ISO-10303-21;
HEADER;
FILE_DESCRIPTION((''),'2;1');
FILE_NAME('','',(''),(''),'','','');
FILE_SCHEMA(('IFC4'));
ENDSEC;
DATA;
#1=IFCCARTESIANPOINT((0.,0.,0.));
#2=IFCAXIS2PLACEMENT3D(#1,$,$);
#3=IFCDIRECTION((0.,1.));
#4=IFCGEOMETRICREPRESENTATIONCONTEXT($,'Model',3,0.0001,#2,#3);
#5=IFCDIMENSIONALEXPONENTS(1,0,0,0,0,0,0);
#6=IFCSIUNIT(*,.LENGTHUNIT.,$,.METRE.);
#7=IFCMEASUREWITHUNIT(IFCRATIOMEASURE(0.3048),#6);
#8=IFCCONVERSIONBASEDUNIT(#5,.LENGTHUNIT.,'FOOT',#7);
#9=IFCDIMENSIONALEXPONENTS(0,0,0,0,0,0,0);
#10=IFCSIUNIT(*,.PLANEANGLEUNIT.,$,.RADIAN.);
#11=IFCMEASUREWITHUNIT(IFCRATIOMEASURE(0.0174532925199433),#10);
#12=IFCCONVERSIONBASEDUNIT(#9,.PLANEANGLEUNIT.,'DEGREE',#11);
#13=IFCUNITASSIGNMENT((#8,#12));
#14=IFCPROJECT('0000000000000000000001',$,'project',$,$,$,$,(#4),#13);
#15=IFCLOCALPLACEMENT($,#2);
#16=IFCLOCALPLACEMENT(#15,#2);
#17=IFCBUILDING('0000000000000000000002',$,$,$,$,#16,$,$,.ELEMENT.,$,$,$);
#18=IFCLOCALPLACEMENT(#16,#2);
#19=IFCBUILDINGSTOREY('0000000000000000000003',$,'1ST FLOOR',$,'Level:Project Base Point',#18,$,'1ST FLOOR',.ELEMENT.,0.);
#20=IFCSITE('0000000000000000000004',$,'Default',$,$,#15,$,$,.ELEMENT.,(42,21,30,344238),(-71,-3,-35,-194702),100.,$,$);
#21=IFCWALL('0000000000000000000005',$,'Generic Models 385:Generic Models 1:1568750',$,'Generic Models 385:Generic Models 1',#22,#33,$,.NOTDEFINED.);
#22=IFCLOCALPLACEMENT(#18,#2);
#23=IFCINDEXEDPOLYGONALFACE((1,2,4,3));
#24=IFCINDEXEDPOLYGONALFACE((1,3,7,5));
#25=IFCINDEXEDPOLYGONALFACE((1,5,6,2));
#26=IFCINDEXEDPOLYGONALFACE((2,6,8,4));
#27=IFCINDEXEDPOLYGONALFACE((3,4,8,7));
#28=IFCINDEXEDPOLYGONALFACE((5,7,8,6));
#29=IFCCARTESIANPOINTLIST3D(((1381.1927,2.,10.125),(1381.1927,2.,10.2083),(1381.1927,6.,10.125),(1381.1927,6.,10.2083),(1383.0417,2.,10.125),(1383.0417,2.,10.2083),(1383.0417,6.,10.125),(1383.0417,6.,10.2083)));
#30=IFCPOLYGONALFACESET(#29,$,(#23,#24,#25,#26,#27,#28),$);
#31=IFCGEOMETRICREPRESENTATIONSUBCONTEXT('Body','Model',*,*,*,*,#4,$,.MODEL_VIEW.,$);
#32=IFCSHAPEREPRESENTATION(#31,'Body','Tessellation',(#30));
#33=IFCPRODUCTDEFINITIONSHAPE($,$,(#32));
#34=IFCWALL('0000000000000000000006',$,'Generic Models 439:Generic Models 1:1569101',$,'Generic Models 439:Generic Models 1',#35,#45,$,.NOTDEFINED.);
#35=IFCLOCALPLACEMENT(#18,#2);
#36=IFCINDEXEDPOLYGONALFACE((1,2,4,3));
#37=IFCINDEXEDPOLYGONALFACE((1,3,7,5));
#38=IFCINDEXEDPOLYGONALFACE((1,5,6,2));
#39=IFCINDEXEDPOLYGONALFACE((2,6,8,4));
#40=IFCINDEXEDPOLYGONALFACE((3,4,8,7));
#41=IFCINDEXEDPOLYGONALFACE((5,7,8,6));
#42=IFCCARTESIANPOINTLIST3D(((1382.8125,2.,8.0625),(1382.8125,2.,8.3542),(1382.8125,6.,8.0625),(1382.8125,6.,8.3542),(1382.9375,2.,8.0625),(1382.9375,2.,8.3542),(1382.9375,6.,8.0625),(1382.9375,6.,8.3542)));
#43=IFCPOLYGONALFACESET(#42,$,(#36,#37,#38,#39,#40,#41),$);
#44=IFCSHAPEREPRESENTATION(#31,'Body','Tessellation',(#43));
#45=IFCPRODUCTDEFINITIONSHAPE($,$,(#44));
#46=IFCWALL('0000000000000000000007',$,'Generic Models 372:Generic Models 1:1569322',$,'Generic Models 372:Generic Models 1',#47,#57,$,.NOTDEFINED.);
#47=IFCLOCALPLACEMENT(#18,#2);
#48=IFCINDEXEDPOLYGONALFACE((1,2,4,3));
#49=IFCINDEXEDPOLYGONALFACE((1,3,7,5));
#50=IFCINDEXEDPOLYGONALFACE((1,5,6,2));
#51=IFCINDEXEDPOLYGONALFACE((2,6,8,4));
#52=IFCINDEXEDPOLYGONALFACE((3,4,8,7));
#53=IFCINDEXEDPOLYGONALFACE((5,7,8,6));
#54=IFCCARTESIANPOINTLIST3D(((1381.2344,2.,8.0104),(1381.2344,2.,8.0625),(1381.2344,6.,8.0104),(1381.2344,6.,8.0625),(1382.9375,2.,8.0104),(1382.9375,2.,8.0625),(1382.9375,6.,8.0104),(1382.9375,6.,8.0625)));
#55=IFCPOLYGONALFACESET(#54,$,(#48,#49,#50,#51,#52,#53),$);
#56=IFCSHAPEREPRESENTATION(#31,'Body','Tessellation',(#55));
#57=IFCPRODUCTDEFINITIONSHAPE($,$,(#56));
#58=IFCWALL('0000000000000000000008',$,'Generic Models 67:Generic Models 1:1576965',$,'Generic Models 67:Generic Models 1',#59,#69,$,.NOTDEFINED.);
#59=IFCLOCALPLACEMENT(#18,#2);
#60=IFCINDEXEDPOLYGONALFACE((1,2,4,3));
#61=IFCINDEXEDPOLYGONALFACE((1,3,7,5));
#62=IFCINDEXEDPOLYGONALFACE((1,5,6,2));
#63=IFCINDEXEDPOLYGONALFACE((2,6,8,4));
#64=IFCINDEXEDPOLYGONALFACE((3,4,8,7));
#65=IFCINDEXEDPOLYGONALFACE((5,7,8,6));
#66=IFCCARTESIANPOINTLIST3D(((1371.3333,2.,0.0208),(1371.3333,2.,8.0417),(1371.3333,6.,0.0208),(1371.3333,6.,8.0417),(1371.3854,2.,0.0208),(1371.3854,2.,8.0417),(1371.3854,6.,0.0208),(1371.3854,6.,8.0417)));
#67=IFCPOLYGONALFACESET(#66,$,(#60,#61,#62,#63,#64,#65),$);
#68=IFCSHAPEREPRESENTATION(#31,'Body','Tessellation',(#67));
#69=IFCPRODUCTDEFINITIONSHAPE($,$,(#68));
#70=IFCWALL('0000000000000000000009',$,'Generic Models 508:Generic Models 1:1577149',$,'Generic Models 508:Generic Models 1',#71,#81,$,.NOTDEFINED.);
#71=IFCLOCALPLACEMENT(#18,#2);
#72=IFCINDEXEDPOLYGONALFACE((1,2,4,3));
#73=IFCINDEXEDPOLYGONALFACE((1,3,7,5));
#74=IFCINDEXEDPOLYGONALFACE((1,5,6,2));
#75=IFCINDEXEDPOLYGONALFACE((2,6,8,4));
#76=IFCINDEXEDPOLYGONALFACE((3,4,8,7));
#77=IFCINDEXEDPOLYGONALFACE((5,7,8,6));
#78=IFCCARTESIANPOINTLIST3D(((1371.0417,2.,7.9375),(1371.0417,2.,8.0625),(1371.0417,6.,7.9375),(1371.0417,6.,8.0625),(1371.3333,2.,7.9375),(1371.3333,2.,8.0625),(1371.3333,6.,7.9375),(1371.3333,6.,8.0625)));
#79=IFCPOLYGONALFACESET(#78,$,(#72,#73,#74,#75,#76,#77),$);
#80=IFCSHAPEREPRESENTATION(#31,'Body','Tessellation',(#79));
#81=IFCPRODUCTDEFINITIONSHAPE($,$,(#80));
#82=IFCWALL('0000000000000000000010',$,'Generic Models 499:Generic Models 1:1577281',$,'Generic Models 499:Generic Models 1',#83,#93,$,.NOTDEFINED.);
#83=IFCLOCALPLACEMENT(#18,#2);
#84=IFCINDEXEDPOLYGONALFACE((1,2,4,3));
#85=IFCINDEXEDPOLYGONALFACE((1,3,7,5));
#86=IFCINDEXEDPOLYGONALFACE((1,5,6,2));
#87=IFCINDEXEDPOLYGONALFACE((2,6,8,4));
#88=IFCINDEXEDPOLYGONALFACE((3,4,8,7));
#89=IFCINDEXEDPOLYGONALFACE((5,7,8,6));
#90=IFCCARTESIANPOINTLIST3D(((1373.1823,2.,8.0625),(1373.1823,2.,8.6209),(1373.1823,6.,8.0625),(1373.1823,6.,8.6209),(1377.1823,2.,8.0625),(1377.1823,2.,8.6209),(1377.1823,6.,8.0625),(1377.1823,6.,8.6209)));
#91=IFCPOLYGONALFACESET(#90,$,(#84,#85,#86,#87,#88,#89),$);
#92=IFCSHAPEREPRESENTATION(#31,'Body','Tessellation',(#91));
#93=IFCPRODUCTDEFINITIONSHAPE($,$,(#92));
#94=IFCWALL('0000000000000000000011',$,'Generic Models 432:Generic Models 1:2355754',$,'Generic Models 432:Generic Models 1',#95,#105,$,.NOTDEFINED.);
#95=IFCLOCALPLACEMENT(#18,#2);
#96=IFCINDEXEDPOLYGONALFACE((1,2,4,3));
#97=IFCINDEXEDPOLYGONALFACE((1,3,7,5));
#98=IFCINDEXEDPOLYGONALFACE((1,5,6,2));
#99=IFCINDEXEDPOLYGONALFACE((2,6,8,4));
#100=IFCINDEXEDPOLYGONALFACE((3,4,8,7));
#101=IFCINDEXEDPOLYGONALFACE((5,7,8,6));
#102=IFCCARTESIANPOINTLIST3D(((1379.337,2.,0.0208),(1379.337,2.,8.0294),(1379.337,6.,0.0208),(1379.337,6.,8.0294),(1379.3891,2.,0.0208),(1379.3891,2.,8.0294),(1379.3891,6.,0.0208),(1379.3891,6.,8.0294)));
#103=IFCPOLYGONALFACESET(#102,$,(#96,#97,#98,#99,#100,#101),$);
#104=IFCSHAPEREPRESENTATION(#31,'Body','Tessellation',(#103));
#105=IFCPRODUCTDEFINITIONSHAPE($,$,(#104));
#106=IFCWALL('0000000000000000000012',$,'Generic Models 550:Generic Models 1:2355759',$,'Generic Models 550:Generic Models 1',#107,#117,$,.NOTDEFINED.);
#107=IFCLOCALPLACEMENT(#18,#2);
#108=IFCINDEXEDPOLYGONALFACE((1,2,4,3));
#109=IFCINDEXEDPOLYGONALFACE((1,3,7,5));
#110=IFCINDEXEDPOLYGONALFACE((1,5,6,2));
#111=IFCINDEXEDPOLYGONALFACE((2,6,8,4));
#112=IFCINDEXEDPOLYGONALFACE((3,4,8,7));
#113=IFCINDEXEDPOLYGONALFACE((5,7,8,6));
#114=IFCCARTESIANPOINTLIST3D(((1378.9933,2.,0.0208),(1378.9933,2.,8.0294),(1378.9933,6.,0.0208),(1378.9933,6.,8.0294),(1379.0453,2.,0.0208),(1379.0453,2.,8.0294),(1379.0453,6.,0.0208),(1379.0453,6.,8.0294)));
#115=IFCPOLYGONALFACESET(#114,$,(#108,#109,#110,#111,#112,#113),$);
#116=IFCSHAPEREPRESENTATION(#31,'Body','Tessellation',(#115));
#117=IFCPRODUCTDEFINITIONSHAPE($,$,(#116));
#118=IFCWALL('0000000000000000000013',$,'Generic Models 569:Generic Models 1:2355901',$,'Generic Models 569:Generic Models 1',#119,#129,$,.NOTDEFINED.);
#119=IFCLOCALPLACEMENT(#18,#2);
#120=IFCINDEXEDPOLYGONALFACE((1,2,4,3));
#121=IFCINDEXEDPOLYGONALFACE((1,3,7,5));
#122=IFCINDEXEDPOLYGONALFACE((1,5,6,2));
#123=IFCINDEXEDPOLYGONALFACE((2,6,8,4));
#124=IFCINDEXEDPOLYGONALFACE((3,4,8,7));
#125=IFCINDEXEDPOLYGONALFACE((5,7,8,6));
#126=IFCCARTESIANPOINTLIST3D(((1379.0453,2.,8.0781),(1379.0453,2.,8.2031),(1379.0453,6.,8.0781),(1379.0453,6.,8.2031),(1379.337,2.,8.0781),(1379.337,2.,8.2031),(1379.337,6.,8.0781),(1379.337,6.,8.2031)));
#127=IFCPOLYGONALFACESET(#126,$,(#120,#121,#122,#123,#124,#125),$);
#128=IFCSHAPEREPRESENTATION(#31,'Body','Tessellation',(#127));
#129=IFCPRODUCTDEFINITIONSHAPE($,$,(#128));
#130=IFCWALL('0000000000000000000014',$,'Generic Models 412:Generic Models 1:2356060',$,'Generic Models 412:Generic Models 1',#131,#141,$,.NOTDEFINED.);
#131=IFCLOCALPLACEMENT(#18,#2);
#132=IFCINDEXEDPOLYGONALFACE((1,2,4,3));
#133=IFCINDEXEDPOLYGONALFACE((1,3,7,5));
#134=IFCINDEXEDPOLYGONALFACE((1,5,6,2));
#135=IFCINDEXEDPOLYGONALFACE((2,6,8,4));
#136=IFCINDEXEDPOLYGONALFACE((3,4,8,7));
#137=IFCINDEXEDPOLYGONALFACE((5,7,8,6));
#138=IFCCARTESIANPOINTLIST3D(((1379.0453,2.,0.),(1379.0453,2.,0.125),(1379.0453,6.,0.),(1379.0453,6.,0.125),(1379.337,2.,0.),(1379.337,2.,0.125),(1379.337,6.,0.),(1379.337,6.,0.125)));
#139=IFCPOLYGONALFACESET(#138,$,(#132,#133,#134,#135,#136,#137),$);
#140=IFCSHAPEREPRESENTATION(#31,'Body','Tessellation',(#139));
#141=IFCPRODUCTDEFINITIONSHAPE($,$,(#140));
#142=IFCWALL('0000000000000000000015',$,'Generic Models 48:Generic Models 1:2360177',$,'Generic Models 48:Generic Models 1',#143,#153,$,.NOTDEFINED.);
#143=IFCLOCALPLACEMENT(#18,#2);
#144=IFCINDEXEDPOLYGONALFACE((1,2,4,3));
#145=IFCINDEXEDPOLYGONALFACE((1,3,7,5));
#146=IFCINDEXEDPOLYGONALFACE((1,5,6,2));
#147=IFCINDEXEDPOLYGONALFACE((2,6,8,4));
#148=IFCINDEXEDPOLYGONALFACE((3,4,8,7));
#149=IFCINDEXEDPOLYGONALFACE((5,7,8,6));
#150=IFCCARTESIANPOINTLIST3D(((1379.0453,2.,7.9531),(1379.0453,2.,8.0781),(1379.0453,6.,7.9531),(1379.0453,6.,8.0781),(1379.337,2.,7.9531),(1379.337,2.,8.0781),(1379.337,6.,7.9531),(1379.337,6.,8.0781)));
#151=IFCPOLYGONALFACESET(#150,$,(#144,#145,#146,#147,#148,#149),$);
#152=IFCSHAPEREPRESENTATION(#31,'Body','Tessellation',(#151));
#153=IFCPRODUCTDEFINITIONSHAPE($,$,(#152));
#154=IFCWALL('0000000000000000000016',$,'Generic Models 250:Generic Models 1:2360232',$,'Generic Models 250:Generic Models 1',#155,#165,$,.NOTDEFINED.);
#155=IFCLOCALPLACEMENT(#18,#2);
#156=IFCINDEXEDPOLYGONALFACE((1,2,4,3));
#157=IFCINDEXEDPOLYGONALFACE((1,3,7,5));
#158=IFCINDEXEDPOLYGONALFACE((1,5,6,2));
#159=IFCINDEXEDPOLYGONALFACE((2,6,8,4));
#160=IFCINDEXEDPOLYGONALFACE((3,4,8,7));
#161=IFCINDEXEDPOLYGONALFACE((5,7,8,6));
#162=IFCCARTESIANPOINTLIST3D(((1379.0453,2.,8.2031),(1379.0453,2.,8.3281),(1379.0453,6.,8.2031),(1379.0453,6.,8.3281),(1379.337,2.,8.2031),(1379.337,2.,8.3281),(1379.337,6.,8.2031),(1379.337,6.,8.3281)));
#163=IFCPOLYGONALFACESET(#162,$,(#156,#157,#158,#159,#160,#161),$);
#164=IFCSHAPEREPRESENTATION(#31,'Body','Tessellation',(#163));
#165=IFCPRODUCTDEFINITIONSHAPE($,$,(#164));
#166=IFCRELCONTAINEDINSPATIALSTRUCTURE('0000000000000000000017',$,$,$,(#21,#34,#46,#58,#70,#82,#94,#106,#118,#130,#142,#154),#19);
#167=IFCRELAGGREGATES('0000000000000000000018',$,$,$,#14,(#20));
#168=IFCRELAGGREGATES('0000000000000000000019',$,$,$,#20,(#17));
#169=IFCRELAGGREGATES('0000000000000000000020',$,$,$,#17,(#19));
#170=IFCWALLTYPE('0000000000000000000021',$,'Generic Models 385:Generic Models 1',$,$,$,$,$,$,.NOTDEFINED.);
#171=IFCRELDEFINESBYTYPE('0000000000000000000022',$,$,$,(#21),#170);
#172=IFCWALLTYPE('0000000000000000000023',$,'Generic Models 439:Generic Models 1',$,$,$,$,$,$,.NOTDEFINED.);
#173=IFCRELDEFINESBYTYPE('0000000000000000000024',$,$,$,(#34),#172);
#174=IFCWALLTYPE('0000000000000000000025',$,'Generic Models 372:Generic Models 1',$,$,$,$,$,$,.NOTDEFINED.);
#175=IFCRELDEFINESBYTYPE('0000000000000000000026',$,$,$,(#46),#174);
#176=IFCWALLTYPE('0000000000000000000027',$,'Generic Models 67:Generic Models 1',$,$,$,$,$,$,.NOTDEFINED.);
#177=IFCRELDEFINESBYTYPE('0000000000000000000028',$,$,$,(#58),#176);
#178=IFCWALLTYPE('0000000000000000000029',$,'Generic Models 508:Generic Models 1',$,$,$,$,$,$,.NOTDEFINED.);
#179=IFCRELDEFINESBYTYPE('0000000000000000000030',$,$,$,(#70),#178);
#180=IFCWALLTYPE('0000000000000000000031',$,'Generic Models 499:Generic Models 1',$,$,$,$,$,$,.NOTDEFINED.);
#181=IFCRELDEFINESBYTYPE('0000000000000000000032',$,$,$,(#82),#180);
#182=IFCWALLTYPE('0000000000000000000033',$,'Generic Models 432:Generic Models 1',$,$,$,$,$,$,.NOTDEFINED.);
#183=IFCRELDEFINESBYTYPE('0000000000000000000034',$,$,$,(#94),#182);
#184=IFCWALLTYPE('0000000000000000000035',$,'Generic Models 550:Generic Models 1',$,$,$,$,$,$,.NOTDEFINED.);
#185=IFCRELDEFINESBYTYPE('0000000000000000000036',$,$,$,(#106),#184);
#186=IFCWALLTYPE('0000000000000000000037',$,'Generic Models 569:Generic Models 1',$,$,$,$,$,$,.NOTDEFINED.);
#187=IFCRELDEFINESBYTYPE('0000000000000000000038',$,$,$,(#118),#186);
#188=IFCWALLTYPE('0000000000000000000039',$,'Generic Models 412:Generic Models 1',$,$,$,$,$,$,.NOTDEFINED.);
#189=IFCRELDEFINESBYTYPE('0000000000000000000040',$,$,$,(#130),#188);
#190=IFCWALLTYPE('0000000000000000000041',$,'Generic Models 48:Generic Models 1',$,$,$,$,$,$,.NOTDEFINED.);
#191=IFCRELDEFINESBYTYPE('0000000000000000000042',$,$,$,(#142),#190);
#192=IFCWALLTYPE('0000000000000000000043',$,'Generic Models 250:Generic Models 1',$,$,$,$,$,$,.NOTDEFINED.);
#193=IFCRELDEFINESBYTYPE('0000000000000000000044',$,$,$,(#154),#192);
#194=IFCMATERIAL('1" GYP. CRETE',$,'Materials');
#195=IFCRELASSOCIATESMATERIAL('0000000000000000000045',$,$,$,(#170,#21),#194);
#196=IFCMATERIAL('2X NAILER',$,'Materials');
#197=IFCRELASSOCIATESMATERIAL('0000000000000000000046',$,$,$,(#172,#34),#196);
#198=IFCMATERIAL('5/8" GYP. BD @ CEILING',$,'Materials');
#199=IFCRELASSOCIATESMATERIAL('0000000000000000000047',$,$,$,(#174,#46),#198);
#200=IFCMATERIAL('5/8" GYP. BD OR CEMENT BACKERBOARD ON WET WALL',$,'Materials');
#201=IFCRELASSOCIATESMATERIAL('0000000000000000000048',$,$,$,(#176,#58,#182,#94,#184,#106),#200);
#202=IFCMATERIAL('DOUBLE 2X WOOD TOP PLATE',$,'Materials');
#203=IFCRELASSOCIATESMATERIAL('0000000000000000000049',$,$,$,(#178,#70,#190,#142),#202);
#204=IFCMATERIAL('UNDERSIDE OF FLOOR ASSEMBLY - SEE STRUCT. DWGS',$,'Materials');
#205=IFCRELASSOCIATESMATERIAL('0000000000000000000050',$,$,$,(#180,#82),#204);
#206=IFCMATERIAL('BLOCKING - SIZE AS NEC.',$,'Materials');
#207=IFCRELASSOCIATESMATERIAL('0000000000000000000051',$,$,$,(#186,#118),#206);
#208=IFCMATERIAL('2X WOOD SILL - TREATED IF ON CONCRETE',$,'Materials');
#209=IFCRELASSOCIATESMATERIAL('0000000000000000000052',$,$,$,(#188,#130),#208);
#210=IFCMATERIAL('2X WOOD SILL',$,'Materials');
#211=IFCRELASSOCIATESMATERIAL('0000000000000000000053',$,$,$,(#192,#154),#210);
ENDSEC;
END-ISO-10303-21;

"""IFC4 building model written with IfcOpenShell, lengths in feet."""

from ifc_helpers import new_model, entity, si_unit, converted_unit, direction, frame, frame_2d, origin, origin_2d_with_axis, place, context, subcontext, project, spatial, rectangle, extrude, material, type_object, element, save


model = new_model("IFC4")

# Units and contexts
model_context = context("Model", 3, precision=0.0001, world=origin(), true_north=direction((0.0, 1.0)))
body_context = subcontext(model_context, "Body", "Model", "MODEL_VIEW")
ifc_project = project(units=[converted_unit("LENGTHUNIT", "FOOT", entity("IfcRatioMeasure", 0.3048), si_unit("LENGTHUNIT", "METRE"), dimensions=[1, 0, 0, 0, 0, 0, 0]), converted_unit("PLANEANGLEUNIT", "DEGREE", entity("IfcRatioMeasure", 0.0174532925199433), si_unit("PLANEANGLEUNIT", "RADIAN"), dimensions=[0, 0, 0, 0, 0, 0, 0])], contexts=[model_context])

# Site, building, storey
site_placement = place(None, origin())
site = spatial("IfcSite", under=ifc_project, at=site_placement, Name="Default", CompositionType="ELEMENT", RefLatitude=(42, 21, 30, 344238), RefLongitude=(-71, -3, -35, -194702), RefElevation=100.0)
building_placement = place(site_placement, origin())
building = spatial("IfcBuilding", under=site, at=building_placement, CompositionType="ELEMENT")
storey_placement = place(building_placement, origin())
storey = spatial("IfcBuildingStorey", under=building, at=storey_placement, Name="1ST FLOOR", ObjectType="Level:Project Base Point", LongName="1ST FLOOR", CompositionType="ELEMENT", Elevation=0.0)

# Walls
ifc_material_1 = material(Name="2X WOOD SILL - TREATED IF ON CONCRETE", Category="Materials")
ifc_material_2 = material(Name="5/8\" GYP. BD OR CEMENT BACKERBOARD ON WET WALL", Category="Materials")
ifc_material_3 = material(Name="DOUBLE 2X WOOD TOP PLATE", Category="Materials")
ifc_material_4 = material(Name="1\" GYP. CRETE", Category="Materials")
wall_type_1 = type_object("IfcWallType", Name="Generic Models 385:Generic Models 1", PredefinedType="NOTDEFINED", material=ifc_material_4)
wall_1_placement = place(storey_placement, frame((1381.1927, 2.0, 10.125), z_axis=(0.0, 0.0, 1.0), x_axis=(0.0, 1.0, 0.0)))
element("IfcWall", 1, at=wall_1_placement, inside=storey, type_object=wall_type_1, material=ifc_material_4, Name="Generic Models 385:Generic Models 1:1568750", ObjectType="Generic Models 385:Generic Models 1", PredefinedType="NOTDEFINED", context=body_context, shape_type="SweptSolid", body=[
    extrude(rectangle(XDim=4.0, YDim=1.849, at=frame_2d((0.0, 0.0), x_axis=(1.0, 0.0))), frame((2.0, -0.9245, 0.0)), (0.0, 0.0, 1.0), 0.0833),
])
ifc_material_5 = material(Name="2X NAILER", Category="Materials")
wall_type_2 = type_object("IfcWallType", Name="Generic Models 439:Generic Models 1", PredefinedType="NOTDEFINED", material=ifc_material_5)
wall_2_placement = place(storey_placement, frame((1382.8125, 2.0, 8.0625), z_axis=(0.0, 0.0, 1.0), x_axis=(0.0, 1.0, 0.0)))
element("IfcWall", 2, at=wall_2_placement, inside=storey, type_object=wall_type_2, material=ifc_material_5, Name="Generic Models 439:Generic Models 1:1569101", ObjectType="Generic Models 439:Generic Models 1", PredefinedType="NOTDEFINED", context=body_context, shape_type="SweptSolid", body=[
    extrude(rectangle(XDim=4.0, YDim=0.125, at=frame_2d((0.0, 0.0), x_axis=(1.0, 0.0))), frame((2.0, -0.0625, 0.0)), (0.0, 0.0, 1.0), 0.2917),
])
ifc_material_6 = material(Name="5/8\" GYP. BD @ CEILING", Category="Materials")
wall_type_3 = type_object("IfcWallType", Name="Generic Models 372:Generic Models 1", PredefinedType="NOTDEFINED", material=ifc_material_6)
wall_3_placement = place(storey_placement, frame((1381.2344, 2.0, 8.0104), z_axis=(0.0, 0.0, 1.0), x_axis=(0.0, 1.0, 0.0)))
element("IfcWall", 3, at=wall_3_placement, inside=storey, type_object=wall_type_3, material=ifc_material_6, Name="Generic Models 372:Generic Models 1:1569322", ObjectType="Generic Models 372:Generic Models 1", PredefinedType="NOTDEFINED", context=body_context, shape_type="SweptSolid", body=[
    extrude(rectangle(XDim=4.0, YDim=1.7031, at=origin_2d_with_axis()), frame((2.0, -0.8516, 0.0)), (0.0, 0.0, 1.0), 0.0521),
])
wall_type_4 = type_object("IfcWallType", Name="Generic Models 67:Generic Models 1", PredefinedType="NOTDEFINED", material=ifc_material_2)
wall_4_placement = place(storey_placement, frame((1371.3333, 2.0, 0.0208), z_axis=(0.0, 0.0, 1.0), x_axis=(0.0, 1.0, 0.0)))
element("IfcWall", 4, at=wall_4_placement, inside=storey, type_object=wall_type_4, material=ifc_material_2, Name="Generic Models 67:Generic Models 1:1576965", ObjectType="Generic Models 67:Generic Models 1", PredefinedType="NOTDEFINED", context=body_context, shape_type="SweptSolid", body=[
    extrude(rectangle(XDim=4.0, YDim=0.0521, at=frame_2d((0.0, 0.0), x_axis=(1.0, 0.0))), frame((2.0, -0.026, 0.0)), (0.0, 0.0, 1.0), 8.0208),
])
wall_type_5 = type_object("IfcWallType", Name="Generic Models 508:Generic Models 1", PredefinedType="NOTDEFINED", material=ifc_material_3)
wall_5_placement = place(storey_placement, frame((1371.0417, 2.0, 7.9375), z_axis=(0.0, 0.0, 1.0), x_axis=(0.0, 1.0, 0.0)))
element("IfcWall", 5, at=wall_5_placement, inside=storey, type_object=wall_type_5, material=ifc_material_3, Name="Generic Models 508:Generic Models 1:1577149", ObjectType="Generic Models 508:Generic Models 1", PredefinedType="NOTDEFINED", context=body_context, shape_type="SweptSolid", body=[
    extrude(rectangle(XDim=4.0, YDim=0.2917, at=frame_2d((0.0, 0.0), x_axis=(1.0, 0.0))), frame((2.0, -0.1458, 0.0)), (0.0, 0.0, 1.0), 0.125),
])
ifc_material_7 = material(Name="UNDERSIDE OF FLOOR ASSEMBLY - SEE STRUCT. DWGS", Category="Materials")
wall_type_6 = type_object("IfcWallType", Name="Generic Models 499:Generic Models 1", PredefinedType="NOTDEFINED", material=ifc_material_7)
wall_6_placement = place(storey_placement, frame((1373.1823, 2.0, 8.0625), z_axis=(0.0, 0.0, 1.0), x_axis=(0.0, 1.0, 0.0)))
element("IfcWall", 6, at=wall_6_placement, inside=storey, type_object=wall_type_6, material=ifc_material_7, Name="Generic Models 499:Generic Models 1:1577281", ObjectType="Generic Models 499:Generic Models 1", PredefinedType="NOTDEFINED", context=body_context, shape_type="SweptSolid", body=[
    extrude(rectangle(XDim=4.0, YDim=4.0, at=origin_2d_with_axis()), frame((2.0, -2.0, 0.0)), (0.0, 0.0, 1.0), 0.5584),
])
wall_type_7 = type_object("IfcWallType", Name="Generic Models 432:Generic Models 1", PredefinedType="NOTDEFINED", material=ifc_material_2)
wall_7_placement = place(storey_placement, frame((1379.337, 2.0, 0.0208), z_axis=(0.0, 0.0, 1.0), x_axis=(0.0, 1.0, 0.0)))
element("IfcWall", 7, at=wall_7_placement, inside=storey, type_object=wall_type_7, material=ifc_material_2, Name="Generic Models 432:Generic Models 1:2355754", ObjectType="Generic Models 432:Generic Models 1", PredefinedType="NOTDEFINED", context=body_context, shape_type="SweptSolid", body=[
    extrude(rectangle(XDim=4.0, YDim=0.0521, at=frame_2d((0.0, 0.0), x_axis=(1.0, 0.0))), frame((2.0, -0.026, 0.0)), (0.0, 0.0, 1.0), 8.0086),
])
wall_type_8 = type_object("IfcWallType", Name="Generic Models 550:Generic Models 1", PredefinedType="NOTDEFINED", material=ifc_material_2)
wall_8_placement = place(storey_placement, frame((1378.9932, 2.0, 0.0208), z_axis=(0.0, 0.0, 1.0), x_axis=(0.0, 1.0, 0.0)))
element("IfcWall", 8, at=wall_8_placement, inside=storey, type_object=wall_type_8, material=ifc_material_2, Name="Generic Models 550:Generic Models 1:2355759", ObjectType="Generic Models 550:Generic Models 1", PredefinedType="NOTDEFINED", context=body_context, shape_type="SweptSolid", body=[
    extrude(rectangle(XDim=4.0, YDim=0.0521, at=frame_2d((0.0, 0.0), x_axis=(1.0, 0.0))), frame((2.0, -0.026, 0.0)), (0.0, 0.0, 1.0), 8.0086),
])
ifc_material_8 = material(Name="BLOCKING - SIZE AS NEC.", Category="Materials")
wall_type_9 = type_object("IfcWallType", Name="Generic Models 569:Generic Models 1", PredefinedType="NOTDEFINED", material=ifc_material_8)
wall_9_placement = place(storey_placement, frame((1379.0453, 2.0, 8.0781), z_axis=(0.0, 0.0, 1.0), x_axis=(0.0, 1.0, 0.0)))
element("IfcWall", 9, at=wall_9_placement, inside=storey, type_object=wall_type_9, material=ifc_material_8, Name="Generic Models 569:Generic Models 1:2355901", ObjectType="Generic Models 569:Generic Models 1", PredefinedType="NOTDEFINED", context=body_context, shape_type="SweptSolid", body=[
    extrude(rectangle(XDim=4.0, YDim=0.2917, at=frame_2d((0.0, 0.0), x_axis=(1.0, 0.0))), frame((2.0, -0.1458, 0.0)), (0.0, 0.0, 1.0), 0.125),
])
wall_type_10 = type_object("IfcWallType", Name="Generic Models 412:Generic Models 1", PredefinedType="NOTDEFINED", material=ifc_material_1)
wall_10_placement = place(storey_placement, frame((1379.0453, 2.0, 0.0), z_axis=(0.0, 0.0, 1.0), x_axis=(0.0, 1.0, 0.0)))
element("IfcWall", 10, at=wall_10_placement, inside=storey, type_object=wall_type_10, material=ifc_material_1, Name="Generic Models 412:Generic Models 1:2356060", ObjectType="Generic Models 412:Generic Models 1", PredefinedType="NOTDEFINED", context=body_context, shape_type="SweptSolid", body=[
    extrude(rectangle(XDim=4.0, YDim=0.2917, at=frame_2d((0.0, 0.0), x_axis=(1.0, 0.0))), frame((2.0, -0.1458, 0.0)), (0.0, 0.0, 1.0), 0.125),
])
wall_type_11 = type_object("IfcWallType", Name="Generic Models 48:Generic Models 1", PredefinedType="NOTDEFINED", material=ifc_material_3)
wall_11_placement = place(storey_placement, frame((1379.0453, 2.0, 7.9531), z_axis=(0.0, 0.0, 1.0), x_axis=(0.0, 1.0, 0.0)))
element("IfcWall", 11, at=wall_11_placement, inside=storey, type_object=wall_type_11, material=ifc_material_3, Name="Generic Models 48:Generic Models 1:2360177", ObjectType="Generic Models 48:Generic Models 1", PredefinedType="NOTDEFINED", context=body_context, shape_type="SweptSolid", body=[
    extrude(rectangle(XDim=4.0, YDim=0.2917, at=frame_2d((0.0, 0.0), x_axis=(1.0, 0.0))), frame((2.0, -0.1458, 0.0)), (0.0, 0.0, 1.0), 0.125),
])
ifc_material_9 = material(Name="2X WOOD SILL", Category="Materials")
wall_type_12 = type_object("IfcWallType", Name="Generic Models 250:Generic Models 1", PredefinedType="NOTDEFINED", material=ifc_material_9)
wall_12_placement = place(storey_placement, frame((1379.0453, 2.0, 8.2031), z_axis=(0.0, 0.0, 1.0), x_axis=(0.0, 1.0, 0.0)))
element("IfcWall", 12, at=wall_12_placement, inside=storey, type_object=wall_type_12, material=ifc_material_9, Name="Generic Models 250:Generic Models 1:2360232", ObjectType="Generic Models 250:Generic Models 1", PredefinedType="NOTDEFINED", context=body_context, shape_type="SweptSolid", body=[
    extrude(rectangle(XDim=4.0, YDim=0.2917, at=frame_2d((0.0, 0.0), x_axis=(1.0, 0.0))), frame((2.0, -0.1458, 0.0)), (0.0, 0.0, 1.0), 0.125),
])

save(model, "model.ifc")
